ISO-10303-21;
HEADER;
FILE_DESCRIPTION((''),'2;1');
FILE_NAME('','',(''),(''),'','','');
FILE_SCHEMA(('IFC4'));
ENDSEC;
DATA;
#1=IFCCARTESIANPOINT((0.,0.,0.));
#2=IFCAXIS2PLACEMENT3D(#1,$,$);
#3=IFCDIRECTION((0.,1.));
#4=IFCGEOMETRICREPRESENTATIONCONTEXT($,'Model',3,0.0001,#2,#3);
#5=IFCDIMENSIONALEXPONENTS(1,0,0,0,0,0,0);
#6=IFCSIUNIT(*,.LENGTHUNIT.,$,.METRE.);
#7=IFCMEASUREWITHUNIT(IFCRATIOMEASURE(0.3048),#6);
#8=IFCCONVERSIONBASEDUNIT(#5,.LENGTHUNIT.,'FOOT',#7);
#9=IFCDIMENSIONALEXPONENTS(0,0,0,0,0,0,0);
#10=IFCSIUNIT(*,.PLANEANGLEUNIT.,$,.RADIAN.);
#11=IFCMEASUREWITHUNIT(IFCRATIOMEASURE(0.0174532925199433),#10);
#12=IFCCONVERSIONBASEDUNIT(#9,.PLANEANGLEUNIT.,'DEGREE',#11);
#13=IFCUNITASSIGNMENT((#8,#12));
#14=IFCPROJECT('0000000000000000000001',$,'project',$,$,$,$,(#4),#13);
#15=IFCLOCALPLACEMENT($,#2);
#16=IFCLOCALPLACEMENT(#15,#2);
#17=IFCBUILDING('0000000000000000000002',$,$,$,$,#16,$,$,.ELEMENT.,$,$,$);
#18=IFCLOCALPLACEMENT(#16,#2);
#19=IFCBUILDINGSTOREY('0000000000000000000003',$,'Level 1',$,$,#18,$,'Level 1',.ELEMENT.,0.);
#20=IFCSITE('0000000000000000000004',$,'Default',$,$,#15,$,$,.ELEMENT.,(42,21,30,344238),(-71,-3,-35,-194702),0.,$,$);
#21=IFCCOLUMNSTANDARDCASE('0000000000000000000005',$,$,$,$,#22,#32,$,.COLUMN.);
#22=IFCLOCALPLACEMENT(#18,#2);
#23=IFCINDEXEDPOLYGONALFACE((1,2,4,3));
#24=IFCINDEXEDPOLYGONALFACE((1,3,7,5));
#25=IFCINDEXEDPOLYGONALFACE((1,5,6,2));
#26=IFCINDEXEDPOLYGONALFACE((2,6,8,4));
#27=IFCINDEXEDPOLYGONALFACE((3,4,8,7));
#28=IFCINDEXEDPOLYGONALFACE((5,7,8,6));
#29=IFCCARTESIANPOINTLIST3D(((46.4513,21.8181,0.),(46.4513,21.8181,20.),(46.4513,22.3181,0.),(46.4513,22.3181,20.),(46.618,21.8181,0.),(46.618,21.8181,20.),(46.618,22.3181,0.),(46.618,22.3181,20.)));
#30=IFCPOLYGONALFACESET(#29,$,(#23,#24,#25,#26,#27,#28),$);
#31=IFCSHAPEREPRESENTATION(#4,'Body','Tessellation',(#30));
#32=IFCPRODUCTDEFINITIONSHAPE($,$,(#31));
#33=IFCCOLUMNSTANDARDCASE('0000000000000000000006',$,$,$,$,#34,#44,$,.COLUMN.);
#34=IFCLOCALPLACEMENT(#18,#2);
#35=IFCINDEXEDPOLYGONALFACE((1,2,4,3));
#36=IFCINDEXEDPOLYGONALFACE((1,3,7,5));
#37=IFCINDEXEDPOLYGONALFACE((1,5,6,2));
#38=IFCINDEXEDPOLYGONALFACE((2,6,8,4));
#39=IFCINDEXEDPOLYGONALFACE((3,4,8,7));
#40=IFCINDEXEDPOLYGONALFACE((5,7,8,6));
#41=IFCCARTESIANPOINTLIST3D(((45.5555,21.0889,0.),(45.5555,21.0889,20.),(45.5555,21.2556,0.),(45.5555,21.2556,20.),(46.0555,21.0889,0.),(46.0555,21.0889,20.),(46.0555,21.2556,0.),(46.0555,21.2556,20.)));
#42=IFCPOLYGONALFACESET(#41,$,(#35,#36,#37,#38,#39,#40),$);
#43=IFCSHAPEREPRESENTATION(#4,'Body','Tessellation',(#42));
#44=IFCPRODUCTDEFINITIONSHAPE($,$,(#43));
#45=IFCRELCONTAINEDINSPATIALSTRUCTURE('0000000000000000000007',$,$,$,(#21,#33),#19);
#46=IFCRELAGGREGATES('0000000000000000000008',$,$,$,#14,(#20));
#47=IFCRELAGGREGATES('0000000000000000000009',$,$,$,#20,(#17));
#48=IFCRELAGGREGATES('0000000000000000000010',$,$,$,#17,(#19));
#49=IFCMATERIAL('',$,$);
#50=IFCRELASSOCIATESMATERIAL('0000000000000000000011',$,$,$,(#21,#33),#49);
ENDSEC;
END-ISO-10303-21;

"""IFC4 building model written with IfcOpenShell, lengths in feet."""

from ifc_helpers import new_model, entity, si_unit, converted_unit, direction, frame, origin, place, context, project, spatial, rectangle, extrude, material, element, save


model = new_model("IFC4")

# Units and contexts
model_context = context("Model", 3, precision=0.0001, world=origin(), true_north=direction((0.0, 1.0)))
ifc_project = project(units=[converted_unit("LENGTHUNIT", "FOOT", entity("IfcRatioMeasure", 0.3048), si_unit("LENGTHUNIT", "METRE"), dimensions=[1, 0, 0, 0, 0, 0, 0]), converted_unit("PLANEANGLEUNIT", "DEGREE", entity("IfcRatioMeasure", 0.0174532925199433), si_unit("PLANEANGLEUNIT", "RADIAN"), dimensions=[0, 0, 0, 0, 0, 0, 0])], contexts=[model_context])

# Site, building, storey
site_placement = place(None, origin())
site = spatial("IfcSite", under=ifc_project, at=site_placement, Name="Default", CompositionType="ELEMENT", RefLatitude=(42, 21, 30, 344238), RefLongitude=(-71, -3, -35, -194702), RefElevation=0.0)
building_placement = place(site_placement, origin())
building = spatial("IfcBuilding", under=site, at=building_placement, CompositionType="ELEMENT")
storey_placement = place(building_placement, origin())
storey = spatial("IfcBuildingStorey", under=building, at=storey_placement, Name="Level 1", LongName="Level 1", CompositionType="ELEMENT", Elevation=0.0)

# Columns
ifc_material_1 = material(Name="")
wall_1_placement = place(storey_placement, frame((46.618, 22.0681, 0.0), z_axis=(0.0, 0.0, 1.0), x_axis=(-1.0, 0.0, 0.0)))
for number, where, z_axis, x_axis in (
    (1, (0.0833, 0.0, 0.0), (0.0, 0.0, 1.0), (1.0, 0.0, 0.0)),
):
    element("IfcColumnStandardCase", number, at=place(wall_1_placement, frame(where, z_axis=z_axis, x_axis=x_axis)), inside=storey, material=ifc_material_1, PredefinedType="COLUMN", context=model_context, shape_type="SweptSolid", body=[
        extrude(rectangle(XDim=0.1667, YDim=0.5), origin(), (0.0, 0.0, 1.0), 20.0),
    ])
wall_2_placement = place(storey_placement, frame((45.8055, 21.2556, 0.0), z_axis=(0.0, 0.0, 1.0), x_axis=(0.0, -1.0, 0.0)))
for number, where, z_axis, x_axis in (
    (2, (0.0833, 0.0, 0.0), (0.0, 0.0, 1.0), (1.0, 0.0, 0.0)),
):
    element("IfcColumnStandardCase", number, at=place(wall_2_placement, frame(where, z_axis=z_axis, x_axis=x_axis)), inside=storey, material=ifc_material_1, PredefinedType="COLUMN", context=model_context, shape_type="SweptSolid", body=[
        extrude(rectangle(XDim=0.1667, YDim=0.5), origin(), (0.0, 0.0, 1.0), 20.0),
    ])

save(model, "model.ifc")
